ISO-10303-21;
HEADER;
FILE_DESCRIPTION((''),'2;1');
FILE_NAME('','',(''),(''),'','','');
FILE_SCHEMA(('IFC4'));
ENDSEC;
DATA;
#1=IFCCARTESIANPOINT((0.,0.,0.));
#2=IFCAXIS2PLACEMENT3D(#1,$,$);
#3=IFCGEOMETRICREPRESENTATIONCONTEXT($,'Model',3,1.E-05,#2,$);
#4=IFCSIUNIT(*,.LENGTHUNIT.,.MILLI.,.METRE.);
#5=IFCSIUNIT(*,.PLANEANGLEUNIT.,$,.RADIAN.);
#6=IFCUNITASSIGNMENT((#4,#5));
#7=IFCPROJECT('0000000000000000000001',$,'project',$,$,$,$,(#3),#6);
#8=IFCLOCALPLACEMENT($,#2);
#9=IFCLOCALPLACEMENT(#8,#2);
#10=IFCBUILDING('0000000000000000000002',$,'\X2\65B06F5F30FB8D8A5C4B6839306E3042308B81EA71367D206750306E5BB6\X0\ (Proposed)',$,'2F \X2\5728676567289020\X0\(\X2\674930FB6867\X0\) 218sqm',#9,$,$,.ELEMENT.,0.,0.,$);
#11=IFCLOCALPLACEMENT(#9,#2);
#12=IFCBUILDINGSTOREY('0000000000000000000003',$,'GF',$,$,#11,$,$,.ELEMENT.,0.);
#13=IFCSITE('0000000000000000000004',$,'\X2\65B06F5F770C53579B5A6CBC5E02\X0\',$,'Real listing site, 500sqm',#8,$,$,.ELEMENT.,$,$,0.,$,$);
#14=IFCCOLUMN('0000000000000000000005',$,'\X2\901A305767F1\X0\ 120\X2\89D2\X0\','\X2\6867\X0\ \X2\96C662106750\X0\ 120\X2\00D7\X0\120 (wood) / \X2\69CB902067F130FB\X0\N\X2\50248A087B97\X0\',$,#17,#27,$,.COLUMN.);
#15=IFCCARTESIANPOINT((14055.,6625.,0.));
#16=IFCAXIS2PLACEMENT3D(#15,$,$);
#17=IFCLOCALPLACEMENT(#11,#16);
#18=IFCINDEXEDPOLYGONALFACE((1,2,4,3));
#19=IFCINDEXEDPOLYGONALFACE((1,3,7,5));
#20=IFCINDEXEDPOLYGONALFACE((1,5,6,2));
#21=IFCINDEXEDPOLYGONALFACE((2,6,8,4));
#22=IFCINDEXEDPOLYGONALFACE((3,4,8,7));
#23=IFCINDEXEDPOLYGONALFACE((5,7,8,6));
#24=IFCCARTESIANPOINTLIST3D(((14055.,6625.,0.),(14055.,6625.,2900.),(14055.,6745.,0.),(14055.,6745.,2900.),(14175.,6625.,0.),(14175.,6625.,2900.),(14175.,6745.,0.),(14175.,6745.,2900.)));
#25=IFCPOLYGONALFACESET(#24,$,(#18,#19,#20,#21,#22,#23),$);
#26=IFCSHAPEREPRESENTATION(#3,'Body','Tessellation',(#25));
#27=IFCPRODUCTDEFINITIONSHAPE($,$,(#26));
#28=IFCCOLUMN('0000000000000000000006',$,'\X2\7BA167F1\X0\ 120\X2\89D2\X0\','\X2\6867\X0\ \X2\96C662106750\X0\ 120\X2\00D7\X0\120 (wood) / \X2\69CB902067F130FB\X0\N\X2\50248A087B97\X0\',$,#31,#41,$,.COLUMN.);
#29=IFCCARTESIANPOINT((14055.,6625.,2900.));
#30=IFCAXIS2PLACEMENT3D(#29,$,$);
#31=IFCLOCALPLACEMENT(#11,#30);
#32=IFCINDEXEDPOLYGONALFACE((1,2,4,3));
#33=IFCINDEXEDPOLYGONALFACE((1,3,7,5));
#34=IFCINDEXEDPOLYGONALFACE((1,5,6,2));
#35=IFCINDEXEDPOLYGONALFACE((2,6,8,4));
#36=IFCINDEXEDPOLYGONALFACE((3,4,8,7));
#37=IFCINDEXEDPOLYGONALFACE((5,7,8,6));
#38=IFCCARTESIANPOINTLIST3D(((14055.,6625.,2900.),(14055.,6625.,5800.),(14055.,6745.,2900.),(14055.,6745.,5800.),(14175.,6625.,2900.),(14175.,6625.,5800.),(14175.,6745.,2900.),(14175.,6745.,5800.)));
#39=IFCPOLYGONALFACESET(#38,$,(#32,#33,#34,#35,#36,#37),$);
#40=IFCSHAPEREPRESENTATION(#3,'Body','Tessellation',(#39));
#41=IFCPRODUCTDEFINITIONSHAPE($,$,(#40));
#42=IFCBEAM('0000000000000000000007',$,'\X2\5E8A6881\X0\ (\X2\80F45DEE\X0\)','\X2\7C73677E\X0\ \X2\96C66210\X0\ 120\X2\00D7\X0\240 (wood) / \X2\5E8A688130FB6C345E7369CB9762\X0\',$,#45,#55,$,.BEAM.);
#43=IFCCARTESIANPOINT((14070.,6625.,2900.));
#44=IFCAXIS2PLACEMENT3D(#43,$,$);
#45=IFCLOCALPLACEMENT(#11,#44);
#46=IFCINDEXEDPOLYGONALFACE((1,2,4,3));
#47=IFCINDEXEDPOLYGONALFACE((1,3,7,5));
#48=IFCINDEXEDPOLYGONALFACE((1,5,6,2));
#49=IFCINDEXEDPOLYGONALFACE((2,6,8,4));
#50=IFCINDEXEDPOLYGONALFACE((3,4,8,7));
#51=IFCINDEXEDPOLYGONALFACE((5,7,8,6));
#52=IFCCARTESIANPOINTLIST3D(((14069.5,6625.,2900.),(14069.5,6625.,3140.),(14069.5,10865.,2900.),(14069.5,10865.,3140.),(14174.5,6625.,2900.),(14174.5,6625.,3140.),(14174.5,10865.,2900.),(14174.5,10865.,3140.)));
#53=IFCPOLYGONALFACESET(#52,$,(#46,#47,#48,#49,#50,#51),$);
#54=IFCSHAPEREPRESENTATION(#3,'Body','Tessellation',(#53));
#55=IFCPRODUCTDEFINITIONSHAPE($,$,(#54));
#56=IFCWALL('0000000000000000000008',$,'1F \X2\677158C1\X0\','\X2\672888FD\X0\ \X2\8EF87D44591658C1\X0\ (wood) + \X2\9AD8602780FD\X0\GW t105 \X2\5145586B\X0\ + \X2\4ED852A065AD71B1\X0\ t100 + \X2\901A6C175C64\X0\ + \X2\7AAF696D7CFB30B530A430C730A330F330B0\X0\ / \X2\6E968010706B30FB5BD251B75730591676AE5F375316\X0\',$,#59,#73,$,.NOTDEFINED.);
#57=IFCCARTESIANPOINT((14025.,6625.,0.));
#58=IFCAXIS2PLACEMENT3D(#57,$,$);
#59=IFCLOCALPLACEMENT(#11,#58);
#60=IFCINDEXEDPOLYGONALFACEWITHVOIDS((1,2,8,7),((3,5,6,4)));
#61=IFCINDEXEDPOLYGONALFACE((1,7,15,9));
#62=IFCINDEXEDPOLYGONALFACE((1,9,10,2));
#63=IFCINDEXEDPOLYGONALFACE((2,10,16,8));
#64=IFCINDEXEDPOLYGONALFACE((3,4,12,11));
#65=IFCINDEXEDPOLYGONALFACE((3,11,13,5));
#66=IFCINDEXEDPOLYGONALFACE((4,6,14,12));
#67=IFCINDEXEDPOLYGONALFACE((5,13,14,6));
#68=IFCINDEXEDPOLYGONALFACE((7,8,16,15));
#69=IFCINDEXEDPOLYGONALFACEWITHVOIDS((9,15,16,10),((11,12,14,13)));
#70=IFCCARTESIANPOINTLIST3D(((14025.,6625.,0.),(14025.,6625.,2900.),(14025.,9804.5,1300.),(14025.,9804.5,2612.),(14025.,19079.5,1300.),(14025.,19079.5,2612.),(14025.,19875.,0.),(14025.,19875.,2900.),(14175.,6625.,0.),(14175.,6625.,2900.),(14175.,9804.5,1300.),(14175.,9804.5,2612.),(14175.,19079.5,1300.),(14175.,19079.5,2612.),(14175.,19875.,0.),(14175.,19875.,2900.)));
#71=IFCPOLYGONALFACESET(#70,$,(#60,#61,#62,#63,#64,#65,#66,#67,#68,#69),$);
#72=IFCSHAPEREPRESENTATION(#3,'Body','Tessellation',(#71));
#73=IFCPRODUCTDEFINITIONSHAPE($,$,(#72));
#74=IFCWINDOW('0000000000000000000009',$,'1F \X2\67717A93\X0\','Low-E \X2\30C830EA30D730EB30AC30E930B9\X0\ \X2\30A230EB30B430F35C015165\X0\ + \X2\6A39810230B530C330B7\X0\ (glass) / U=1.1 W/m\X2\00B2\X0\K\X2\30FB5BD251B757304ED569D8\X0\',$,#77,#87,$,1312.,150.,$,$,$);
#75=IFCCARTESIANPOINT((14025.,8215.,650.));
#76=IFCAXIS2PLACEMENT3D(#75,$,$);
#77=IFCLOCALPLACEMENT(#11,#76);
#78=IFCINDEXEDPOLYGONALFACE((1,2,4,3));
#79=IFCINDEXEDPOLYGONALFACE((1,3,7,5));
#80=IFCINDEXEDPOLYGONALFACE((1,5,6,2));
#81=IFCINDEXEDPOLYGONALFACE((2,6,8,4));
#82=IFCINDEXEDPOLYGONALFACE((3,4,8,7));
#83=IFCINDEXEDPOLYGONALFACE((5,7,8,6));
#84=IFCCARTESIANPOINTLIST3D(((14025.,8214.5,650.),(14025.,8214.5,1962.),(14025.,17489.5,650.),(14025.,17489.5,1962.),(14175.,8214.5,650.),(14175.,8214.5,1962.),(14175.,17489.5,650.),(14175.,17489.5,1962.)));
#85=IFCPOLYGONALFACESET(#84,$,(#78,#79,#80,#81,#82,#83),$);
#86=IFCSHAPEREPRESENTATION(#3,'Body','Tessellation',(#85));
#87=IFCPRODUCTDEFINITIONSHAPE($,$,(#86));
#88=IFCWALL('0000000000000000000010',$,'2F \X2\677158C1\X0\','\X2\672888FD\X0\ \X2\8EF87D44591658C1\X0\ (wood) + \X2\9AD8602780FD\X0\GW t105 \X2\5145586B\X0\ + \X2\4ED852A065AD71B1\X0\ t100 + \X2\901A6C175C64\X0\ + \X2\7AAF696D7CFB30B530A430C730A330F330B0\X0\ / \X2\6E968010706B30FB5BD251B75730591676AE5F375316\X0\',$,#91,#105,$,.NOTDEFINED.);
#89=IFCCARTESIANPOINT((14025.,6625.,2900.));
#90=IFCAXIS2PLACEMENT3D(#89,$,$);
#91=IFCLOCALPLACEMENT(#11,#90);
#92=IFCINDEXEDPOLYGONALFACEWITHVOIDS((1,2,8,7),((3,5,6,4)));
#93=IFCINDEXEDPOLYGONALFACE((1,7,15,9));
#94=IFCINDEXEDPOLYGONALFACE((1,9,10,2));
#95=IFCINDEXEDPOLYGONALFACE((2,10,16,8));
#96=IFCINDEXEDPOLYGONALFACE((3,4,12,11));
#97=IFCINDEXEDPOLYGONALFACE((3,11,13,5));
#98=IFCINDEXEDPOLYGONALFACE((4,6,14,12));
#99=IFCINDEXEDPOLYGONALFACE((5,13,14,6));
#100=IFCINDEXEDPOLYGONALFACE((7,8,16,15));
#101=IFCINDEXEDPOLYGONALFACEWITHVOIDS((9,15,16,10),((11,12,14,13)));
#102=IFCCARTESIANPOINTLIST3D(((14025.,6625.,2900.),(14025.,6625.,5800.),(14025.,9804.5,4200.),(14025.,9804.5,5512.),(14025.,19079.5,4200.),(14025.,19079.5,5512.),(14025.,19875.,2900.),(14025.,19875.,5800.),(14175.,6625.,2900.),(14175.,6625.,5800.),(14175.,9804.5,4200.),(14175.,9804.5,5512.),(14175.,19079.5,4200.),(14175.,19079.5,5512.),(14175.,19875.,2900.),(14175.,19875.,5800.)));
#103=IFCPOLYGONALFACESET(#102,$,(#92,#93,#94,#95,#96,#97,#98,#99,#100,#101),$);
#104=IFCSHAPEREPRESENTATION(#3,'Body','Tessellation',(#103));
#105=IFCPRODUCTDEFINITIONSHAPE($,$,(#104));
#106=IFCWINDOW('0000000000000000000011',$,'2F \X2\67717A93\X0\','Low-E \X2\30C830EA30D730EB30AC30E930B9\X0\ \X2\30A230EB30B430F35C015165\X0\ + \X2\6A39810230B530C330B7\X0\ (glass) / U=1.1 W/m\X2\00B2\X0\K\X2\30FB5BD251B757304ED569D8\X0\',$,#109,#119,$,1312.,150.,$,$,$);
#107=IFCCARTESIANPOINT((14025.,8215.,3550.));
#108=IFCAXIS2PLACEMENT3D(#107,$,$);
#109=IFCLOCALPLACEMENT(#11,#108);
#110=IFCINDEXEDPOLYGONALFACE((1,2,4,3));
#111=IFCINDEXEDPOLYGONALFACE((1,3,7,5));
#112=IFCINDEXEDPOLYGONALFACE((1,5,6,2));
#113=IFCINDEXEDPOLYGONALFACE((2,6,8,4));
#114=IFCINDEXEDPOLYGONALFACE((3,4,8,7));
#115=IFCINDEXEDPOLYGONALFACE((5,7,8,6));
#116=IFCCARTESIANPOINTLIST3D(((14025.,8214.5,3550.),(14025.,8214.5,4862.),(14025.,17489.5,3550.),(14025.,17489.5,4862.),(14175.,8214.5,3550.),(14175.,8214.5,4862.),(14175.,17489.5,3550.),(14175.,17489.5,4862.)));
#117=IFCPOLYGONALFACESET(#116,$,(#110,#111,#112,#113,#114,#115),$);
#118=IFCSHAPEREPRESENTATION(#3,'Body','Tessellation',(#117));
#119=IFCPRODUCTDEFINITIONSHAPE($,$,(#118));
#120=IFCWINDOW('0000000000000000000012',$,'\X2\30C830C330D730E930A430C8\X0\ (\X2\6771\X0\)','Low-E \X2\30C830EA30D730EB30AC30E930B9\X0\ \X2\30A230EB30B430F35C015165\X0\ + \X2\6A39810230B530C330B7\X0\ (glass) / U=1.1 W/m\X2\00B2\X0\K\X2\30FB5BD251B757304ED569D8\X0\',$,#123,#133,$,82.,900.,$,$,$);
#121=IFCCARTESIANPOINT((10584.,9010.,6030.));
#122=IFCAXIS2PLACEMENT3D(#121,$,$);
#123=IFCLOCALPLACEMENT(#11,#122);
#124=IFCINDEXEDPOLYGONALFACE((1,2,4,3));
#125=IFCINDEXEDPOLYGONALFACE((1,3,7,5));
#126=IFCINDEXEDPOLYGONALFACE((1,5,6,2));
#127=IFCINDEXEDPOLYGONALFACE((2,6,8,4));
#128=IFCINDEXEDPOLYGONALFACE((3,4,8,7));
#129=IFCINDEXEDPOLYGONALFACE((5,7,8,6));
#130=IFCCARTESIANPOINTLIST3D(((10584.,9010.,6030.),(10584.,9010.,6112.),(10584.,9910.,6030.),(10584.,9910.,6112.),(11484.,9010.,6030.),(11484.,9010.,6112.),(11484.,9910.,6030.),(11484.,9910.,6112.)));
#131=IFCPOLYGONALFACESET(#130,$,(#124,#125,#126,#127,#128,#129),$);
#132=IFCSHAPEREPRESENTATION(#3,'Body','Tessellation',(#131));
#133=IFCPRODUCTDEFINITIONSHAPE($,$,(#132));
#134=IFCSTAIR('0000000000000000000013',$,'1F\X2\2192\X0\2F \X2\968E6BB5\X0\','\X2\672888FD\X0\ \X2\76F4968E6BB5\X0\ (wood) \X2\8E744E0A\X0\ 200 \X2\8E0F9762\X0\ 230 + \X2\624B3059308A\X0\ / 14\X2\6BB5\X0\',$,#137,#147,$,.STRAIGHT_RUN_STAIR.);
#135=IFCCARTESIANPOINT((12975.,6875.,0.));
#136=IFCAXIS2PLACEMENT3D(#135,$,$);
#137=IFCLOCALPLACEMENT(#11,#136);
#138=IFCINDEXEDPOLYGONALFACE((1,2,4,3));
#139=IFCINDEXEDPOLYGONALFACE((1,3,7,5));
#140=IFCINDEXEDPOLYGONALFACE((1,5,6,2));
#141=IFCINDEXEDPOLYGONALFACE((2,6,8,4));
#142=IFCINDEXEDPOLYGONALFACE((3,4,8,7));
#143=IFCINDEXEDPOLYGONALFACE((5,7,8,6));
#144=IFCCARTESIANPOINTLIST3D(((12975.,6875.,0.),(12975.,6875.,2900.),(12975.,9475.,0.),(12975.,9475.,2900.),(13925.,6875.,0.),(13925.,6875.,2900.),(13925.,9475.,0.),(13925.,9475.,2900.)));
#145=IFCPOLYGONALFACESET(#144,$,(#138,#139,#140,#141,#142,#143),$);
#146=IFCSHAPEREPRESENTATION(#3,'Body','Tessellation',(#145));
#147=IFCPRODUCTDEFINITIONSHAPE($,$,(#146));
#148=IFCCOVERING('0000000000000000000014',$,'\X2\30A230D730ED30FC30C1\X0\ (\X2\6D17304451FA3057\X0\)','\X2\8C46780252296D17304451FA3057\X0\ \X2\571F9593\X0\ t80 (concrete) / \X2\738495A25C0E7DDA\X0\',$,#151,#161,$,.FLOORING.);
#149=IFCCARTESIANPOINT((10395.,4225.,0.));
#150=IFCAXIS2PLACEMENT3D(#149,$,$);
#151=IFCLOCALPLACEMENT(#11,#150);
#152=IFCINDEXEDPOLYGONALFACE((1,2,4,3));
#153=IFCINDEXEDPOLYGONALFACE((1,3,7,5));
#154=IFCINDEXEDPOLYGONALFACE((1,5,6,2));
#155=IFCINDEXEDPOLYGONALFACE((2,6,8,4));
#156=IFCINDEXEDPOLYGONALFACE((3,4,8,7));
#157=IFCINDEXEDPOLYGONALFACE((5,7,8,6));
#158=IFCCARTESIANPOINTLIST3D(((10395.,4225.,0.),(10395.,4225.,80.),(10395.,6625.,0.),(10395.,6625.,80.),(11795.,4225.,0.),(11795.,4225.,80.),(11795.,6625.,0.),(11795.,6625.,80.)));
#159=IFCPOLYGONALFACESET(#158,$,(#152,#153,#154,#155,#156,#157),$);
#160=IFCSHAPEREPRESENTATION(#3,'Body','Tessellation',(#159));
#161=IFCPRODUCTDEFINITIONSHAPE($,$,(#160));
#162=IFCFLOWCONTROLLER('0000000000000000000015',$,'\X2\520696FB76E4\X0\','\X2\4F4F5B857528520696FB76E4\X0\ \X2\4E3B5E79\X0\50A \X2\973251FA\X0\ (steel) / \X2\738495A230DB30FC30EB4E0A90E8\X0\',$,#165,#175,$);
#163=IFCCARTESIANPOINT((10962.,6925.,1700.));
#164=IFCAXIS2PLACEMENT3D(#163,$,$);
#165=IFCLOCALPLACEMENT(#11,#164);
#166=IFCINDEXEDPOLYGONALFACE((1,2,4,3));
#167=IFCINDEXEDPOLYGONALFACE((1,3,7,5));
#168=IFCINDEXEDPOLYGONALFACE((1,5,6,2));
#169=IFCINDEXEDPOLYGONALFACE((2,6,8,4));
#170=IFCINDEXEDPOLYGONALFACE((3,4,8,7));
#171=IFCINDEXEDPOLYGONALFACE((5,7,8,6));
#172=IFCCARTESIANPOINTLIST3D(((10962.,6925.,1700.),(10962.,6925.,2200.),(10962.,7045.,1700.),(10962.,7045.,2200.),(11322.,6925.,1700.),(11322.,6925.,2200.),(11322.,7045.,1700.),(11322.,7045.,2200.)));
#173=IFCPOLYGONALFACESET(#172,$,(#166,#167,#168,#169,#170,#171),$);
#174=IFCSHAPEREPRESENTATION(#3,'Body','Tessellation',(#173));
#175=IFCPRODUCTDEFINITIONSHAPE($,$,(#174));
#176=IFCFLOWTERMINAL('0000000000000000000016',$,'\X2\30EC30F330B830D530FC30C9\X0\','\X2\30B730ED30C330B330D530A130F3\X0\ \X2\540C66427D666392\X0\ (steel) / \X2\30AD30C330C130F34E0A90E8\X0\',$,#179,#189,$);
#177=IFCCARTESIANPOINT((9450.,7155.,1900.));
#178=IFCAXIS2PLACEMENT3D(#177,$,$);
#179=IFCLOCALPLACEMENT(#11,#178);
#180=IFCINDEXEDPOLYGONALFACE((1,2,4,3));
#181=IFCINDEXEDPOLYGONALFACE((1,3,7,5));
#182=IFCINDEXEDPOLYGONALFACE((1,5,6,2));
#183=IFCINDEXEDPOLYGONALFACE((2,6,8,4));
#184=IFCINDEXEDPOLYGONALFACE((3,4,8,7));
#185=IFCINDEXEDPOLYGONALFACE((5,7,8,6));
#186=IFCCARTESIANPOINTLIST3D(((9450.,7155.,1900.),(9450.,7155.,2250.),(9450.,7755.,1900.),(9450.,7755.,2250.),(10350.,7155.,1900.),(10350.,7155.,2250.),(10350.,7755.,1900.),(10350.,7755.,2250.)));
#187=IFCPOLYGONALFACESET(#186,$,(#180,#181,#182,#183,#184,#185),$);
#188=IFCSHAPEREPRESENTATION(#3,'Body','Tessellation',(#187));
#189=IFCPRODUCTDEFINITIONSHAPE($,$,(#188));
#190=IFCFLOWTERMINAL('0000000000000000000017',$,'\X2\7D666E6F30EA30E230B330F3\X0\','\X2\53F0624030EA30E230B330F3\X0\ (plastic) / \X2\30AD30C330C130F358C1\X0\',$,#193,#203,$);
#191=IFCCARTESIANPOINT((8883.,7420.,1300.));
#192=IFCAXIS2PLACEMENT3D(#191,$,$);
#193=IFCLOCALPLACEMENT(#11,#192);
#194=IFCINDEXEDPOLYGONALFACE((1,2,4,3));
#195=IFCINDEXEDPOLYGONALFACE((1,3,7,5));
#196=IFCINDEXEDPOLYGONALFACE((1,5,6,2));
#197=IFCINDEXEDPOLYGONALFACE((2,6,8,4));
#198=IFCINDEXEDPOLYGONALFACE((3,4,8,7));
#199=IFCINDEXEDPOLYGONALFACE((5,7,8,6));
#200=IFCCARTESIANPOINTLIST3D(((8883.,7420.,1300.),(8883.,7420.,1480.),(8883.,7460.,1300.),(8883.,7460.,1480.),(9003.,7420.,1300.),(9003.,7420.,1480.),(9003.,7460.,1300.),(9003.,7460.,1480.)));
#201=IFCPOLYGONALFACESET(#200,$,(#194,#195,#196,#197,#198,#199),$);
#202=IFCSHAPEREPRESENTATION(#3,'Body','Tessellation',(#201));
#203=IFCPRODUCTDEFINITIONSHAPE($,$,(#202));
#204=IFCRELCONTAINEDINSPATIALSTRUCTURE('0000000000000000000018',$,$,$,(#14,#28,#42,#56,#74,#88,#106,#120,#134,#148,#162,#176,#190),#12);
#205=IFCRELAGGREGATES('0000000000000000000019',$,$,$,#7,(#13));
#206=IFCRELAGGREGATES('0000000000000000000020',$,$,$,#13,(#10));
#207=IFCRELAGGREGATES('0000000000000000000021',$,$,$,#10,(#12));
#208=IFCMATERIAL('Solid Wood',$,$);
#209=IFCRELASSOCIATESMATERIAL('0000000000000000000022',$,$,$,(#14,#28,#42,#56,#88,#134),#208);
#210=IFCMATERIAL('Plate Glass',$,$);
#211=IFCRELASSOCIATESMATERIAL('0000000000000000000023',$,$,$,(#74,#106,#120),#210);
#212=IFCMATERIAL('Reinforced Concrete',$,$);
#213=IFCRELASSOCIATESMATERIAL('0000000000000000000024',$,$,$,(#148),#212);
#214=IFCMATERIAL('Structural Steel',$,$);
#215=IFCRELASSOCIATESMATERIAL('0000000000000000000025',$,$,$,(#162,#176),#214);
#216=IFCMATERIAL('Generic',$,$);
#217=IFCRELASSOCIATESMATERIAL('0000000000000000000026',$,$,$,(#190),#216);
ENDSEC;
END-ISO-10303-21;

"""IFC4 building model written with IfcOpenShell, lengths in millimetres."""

from ifc_helpers import new_model, si_unit, frame, frame_2d, origin, place, context, project, spatial, rectangle, extrude, material, element, fill, save


model = new_model("IFC4")

# Units and contexts
model_context = context("Model", 3, precision=1e-05, world=origin())
ifc_project = project(units=[si_unit("LENGTHUNIT", "METRE", prefix="MILLI"), si_unit("PLANEANGLEUNIT", "RADIAN")], contexts=[model_context])

# Site, building, storey
site_placement = place(None, origin())
site = spatial("IfcSite", under=ifc_project, at=site_placement, Name="新潟県南魚沼市", ObjectType="Real listing site, 500sqm", CompositionType="ELEMENT", RefElevation=0.0)
building_placement = place(site_placement, origin())
building = spatial("IfcBuilding", under=site, at=building_placement, Name="新潟・越屋根のある自然素材の家 (Proposed)", ObjectType="2F 在来木造(杉・桧) 218sqm", CompositionType="ELEMENT", ElevationOfRefHeight=0.0, ElevationOfTerrain=0.0)
storey_placement = place(building_placement, origin())
storey = spatial("IfcBuildingStorey", under=building, at=storey_placement, Name="GF", CompositionType="ELEMENT", Elevation=0.0)

# Columns
ifc_material_1 = material(Name="Solid Wood")
column_1_placement = place(storey_placement, frame((14055.0, 6625.0, 0.0)))
element("IfcColumn", 1, at=column_1_placement, inside=storey, material=ifc_material_1, Name="通し柱 120角", Description="桧 集成材 120×120 (wood) / 構造柱・N値計算", PredefinedType="COLUMN", context=model_context, shape_type="SweptSolid", body=[
    extrude(rectangle(XDim=120.0, YDim=120.0, at=frame_2d((60.0, 60.0))), frame((14055.0, 6625.0, 0.0)), (0.0, 0.0, 1.0), 2900.0),
])
column_2_placement = place(storey_placement, frame((14055.0, 6625.0, 2900.0)))
element("IfcColumn", 2, at=column_2_placement, inside=storey, material=ifc_material_1, Name="管柱 120角", Description="桧 集成材 120×120 (wood) / 構造柱・N値計算", PredefinedType="COLUMN", context=model_context, shape_type="SweptSolid", body=[
    extrude(rectangle(XDim=120.0, YDim=120.0, at=frame_2d((60.0, 60.0))), frame((14055.0, 6625.0, 2900.0)), (0.0, 0.0, 1.0), 2900.0),
])

# Beam
beam_1_placement = place(storey_placement, frame((14070.0, 6625.0, 2900.0)))
element("IfcBeam", 3, at=beam_1_placement, inside=storey, material=ifc_material_1, Name="床梁 (胴差)", Description="米松 集成 120×240 (wood) / 床梁・水平構面", PredefinedType="BEAM", context=model_context, shape_type="SweptSolid", body=[
    extrude(rectangle(XDim=105.0, YDim=4240.0, at=frame_2d((52.0, 2120.0))), frame((14070.0, 6625.0, 2900.0)), (0.0, 0.0, 1.0), 240.0),
])

# Wall, opening, window
wall_1_placement = place(storey_placement, frame((14025.0, 6625.0, 0.0)))
wall_1 = element("IfcWall", 4, at=wall_1_placement, inside=storey, material=ifc_material_1, Name="1F 東壁", Description="木製 軸組外壁 (wood) + 高性能GW t105 充填 + 付加断熱 t100 + 通気層 + 窯業系サイディング / 準耐火・寒冷地外皮強化", PredefinedType="NOTDEFINED", context=model_context, shape_type="SweptSolid", body=[
    extrude(rectangle(XDim=150.0, YDim=13250.0, at=frame_2d((75.0, 6625.0))), frame((14025.0, 6625.0, 0.0)), (0.0, 0.0, 1.0), 2900.0),
])
opening_1_placement = place(storey_placement, frame((14025.0, 8215.0, 650.0)))
opening_1 = element("IfcOpeningElement", 5, at=opening_1_placement, cuts=wall_1, PredefinedType="NOTDEFINED", context=model_context, shape_type="SweptSolid", body=[
    extrude(rectangle(XDim=150.0, YDim=9275.0, at=frame_2d((75.0, 4637.0))), frame((14025.0, 8215.0, 650.0)), (0.0, 0.0, 1.0), 1312.0),
])
ifc_material_2 = material(Name="Plate Glass")
window_1_placement = place(storey_placement, frame((14025.0, 8215.0, 650.0)))
window_1 = element("IfcWindow", 6, at=window_1_placement, inside=storey, material=ifc_material_2, Name="1F 東窓", Description="Low-E トリプルガラス アルゴン封入 + 樹脂サッシ (glass) / U=1.1 W/m²K・寒冷地仕様", OverallHeight=1312.0, OverallWidth=150.0, context=model_context, shape_type="SweptSolid", body=[
    extrude(rectangle(XDim=150.0, YDim=9275.0, at=frame_2d((75.0, 4637.0))), frame((14025.0, 8215.0, 650.0)), (0.0, 0.0, 1.0), 1312.0),
])
fill(opening_1, window_1)

# Wall, opening, window
wall_2_placement = place(storey_placement, frame((14025.0, 6625.0, 2900.0)))
wall_2 = element("IfcWall", 7, at=wall_2_placement, inside=storey, material=ifc_material_1, Name="2F 東壁", Description="木製 軸組外壁 (wood) + 高性能GW t105 充填 + 付加断熱 t100 + 通気層 + 窯業系サイディング / 準耐火・寒冷地外皮強化", PredefinedType="NOTDEFINED", context=model_context, shape_type="SweptSolid", body=[
    extrude(rectangle(XDim=150.0, YDim=13250.0, at=frame_2d((75.0, 6625.0))), frame((14025.0, 6625.0, 2900.0)), (0.0, 0.0, 1.0), 2900.0),
])
opening_2_placement = place(storey_placement, frame((14025.0, 8215.0, 3550.0)))
opening_2 = element("IfcOpeningElement", 8, at=opening_2_placement, cuts=wall_2, PredefinedType="NOTDEFINED", context=model_context, shape_type="SweptSolid", body=[
    extrude(rectangle(XDim=150.0, YDim=9275.0, at=frame_2d((75.0, 4637.0))), frame((14025.0, 8215.0, 3550.0)), (0.0, 0.0, 1.0), 1312.0),
])
window_2_placement = place(storey_placement, frame((14025.0, 8215.0, 3550.0)))
window_2 = element("IfcWindow", 9, at=window_2_placement, inside=storey, material=ifc_material_2, Name="2F 東窓", Description="Low-E トリプルガラス アルゴン封入 + 樹脂サッシ (glass) / U=1.1 W/m²K・寒冷地仕様", OverallHeight=1312.0, OverallWidth=150.0, context=model_context, shape_type="SweptSolid", body=[
    extrude(rectangle(XDim=150.0, YDim=9275.0, at=frame_2d((75.0, 4637.0))), frame((14025.0, 8215.0, 3550.0)), (0.0, 0.0, 1.0), 1312.0),
])
fill(opening_2, window_2)

# Window
window_3_placement = place(storey_placement, frame((10584.0, 9010.0, 6030.0)))
element("IfcWindow", 10, at=window_3_placement, inside=storey, material=ifc_material_2, Name="トップライト (東)", Description="Low-E トリプルガラス アルゴン封入 + 樹脂サッシ (glass) / U=1.1 W/m²K・寒冷地仕様", OverallHeight=82.0, OverallWidth=900.0, context=model_context, shape_type="SweptSolid", body=[
    extrude(rectangle(XDim=900.0, YDim=900.0, at=frame_2d((450.0, 450.0))), frame((10584.0, 9010.0, 6030.0)), (0.0, 0.0, 1.0), 82.0),
])

# Stair
stair_placement = place(storey_placement, frame((12975.0, 6875.0, 0.0)))
element("IfcStair", 11, at=stair_placement, inside=storey, material=ifc_material_1, Name="1F→2F 階段", Description="木製 直階段 (wood) 蹴上 200 踏面 230 + 手すり / 14段", PredefinedType="STRAIGHT_RUN_STAIR", context=model_context, shape_type="SweptSolid", body=[
    extrude(rectangle(XDim=950.0, YDim=2600.0, at=frame_2d((475.0, 1300.0))), frame((12975.0, 6875.0, 0.0)), (0.0, 0.0, 1.0), 2900.0),
])

# Covering
ifc_material_3 = material(Name="Reinforced Concrete")
covering_placement = place(storey_placement, frame((10395.0, 4225.0, 0.0)))
element("IfcCovering", 12, at=covering_placement, inside=storey, material=ifc_material_3, Name="アプローチ (洗い出し)", Description="豆砂利洗い出し 土間 t80 (concrete) / 玄関導線", PredefinedType="FLOORING", context=model_context, shape_type="SweptSolid", body=[
    extrude(rectangle(XDim=1400.0, YDim=2400.0, at=frame_2d((700.0, 1200.0))), frame((10395.0, 4225.0, 0.0)), (0.0, 0.0, 1.0), 80.0),
])

# Flow controller
ifc_material_4 = material(Name="Structural Steel")
flow_controller_placement = place(storey_placement, frame((10962.0, 6925.0, 1700.0)))
element("IfcFlowController", 13, at=flow_controller_placement, inside=storey, material=ifc_material_4, Name="分電盤", Description="住宅用分電盤 主幹50A 露出 (steel) / 玄関ホール上部", context=model_context, shape_type="SweptSolid", body=[
    extrude(rectangle(XDim=360.0, YDim=120.0, at=frame_2d((180.0, 60.0))), frame((10962.0, 6925.0, 1700.0)), (0.0, 0.0, 1.0), 500.0),
])

# Flow terminals
flow_terminal_1_placement = place(storey_placement, frame((9450.0, 7155.0, 1900.0)))
element("IfcFlowTerminal", 14, at=flow_terminal_1_placement, inside=storey, material=ifc_material_4, Name="レンジフード", Description="シロッコファン 同時給排 (steel) / キッチン上部", context=model_context, shape_type="SweptSolid", body=[
    extrude(rectangle(XDim=900.0, YDim=600.0, at=frame_2d((450.0, 300.0))), frame((9450.0, 7155.0, 1900.0)), (0.0, 0.0, 1.0), 350.0),
])
ifc_material_5 = material(Name="Generic")
flow_terminal_2_placement = place(storey_placement, frame((8883.0, 7420.0, 1300.0)))
element("IfcFlowTerminal", 15, at=flow_terminal_2_placement, inside=storey, material=ifc_material_5, Name="給湯リモコン", Description="台所リモコン (plastic) / キッチン壁", context=model_context, shape_type="SweptSolid", body=[
    extrude(rectangle(XDim=120.0, YDim=40.0, at=frame_2d((60.0, 20.0))), frame((8883.0, 7420.0, 1300.0)), (0.0, 0.0, 1.0), 180.0),
])

save(model, "model.ifc")
